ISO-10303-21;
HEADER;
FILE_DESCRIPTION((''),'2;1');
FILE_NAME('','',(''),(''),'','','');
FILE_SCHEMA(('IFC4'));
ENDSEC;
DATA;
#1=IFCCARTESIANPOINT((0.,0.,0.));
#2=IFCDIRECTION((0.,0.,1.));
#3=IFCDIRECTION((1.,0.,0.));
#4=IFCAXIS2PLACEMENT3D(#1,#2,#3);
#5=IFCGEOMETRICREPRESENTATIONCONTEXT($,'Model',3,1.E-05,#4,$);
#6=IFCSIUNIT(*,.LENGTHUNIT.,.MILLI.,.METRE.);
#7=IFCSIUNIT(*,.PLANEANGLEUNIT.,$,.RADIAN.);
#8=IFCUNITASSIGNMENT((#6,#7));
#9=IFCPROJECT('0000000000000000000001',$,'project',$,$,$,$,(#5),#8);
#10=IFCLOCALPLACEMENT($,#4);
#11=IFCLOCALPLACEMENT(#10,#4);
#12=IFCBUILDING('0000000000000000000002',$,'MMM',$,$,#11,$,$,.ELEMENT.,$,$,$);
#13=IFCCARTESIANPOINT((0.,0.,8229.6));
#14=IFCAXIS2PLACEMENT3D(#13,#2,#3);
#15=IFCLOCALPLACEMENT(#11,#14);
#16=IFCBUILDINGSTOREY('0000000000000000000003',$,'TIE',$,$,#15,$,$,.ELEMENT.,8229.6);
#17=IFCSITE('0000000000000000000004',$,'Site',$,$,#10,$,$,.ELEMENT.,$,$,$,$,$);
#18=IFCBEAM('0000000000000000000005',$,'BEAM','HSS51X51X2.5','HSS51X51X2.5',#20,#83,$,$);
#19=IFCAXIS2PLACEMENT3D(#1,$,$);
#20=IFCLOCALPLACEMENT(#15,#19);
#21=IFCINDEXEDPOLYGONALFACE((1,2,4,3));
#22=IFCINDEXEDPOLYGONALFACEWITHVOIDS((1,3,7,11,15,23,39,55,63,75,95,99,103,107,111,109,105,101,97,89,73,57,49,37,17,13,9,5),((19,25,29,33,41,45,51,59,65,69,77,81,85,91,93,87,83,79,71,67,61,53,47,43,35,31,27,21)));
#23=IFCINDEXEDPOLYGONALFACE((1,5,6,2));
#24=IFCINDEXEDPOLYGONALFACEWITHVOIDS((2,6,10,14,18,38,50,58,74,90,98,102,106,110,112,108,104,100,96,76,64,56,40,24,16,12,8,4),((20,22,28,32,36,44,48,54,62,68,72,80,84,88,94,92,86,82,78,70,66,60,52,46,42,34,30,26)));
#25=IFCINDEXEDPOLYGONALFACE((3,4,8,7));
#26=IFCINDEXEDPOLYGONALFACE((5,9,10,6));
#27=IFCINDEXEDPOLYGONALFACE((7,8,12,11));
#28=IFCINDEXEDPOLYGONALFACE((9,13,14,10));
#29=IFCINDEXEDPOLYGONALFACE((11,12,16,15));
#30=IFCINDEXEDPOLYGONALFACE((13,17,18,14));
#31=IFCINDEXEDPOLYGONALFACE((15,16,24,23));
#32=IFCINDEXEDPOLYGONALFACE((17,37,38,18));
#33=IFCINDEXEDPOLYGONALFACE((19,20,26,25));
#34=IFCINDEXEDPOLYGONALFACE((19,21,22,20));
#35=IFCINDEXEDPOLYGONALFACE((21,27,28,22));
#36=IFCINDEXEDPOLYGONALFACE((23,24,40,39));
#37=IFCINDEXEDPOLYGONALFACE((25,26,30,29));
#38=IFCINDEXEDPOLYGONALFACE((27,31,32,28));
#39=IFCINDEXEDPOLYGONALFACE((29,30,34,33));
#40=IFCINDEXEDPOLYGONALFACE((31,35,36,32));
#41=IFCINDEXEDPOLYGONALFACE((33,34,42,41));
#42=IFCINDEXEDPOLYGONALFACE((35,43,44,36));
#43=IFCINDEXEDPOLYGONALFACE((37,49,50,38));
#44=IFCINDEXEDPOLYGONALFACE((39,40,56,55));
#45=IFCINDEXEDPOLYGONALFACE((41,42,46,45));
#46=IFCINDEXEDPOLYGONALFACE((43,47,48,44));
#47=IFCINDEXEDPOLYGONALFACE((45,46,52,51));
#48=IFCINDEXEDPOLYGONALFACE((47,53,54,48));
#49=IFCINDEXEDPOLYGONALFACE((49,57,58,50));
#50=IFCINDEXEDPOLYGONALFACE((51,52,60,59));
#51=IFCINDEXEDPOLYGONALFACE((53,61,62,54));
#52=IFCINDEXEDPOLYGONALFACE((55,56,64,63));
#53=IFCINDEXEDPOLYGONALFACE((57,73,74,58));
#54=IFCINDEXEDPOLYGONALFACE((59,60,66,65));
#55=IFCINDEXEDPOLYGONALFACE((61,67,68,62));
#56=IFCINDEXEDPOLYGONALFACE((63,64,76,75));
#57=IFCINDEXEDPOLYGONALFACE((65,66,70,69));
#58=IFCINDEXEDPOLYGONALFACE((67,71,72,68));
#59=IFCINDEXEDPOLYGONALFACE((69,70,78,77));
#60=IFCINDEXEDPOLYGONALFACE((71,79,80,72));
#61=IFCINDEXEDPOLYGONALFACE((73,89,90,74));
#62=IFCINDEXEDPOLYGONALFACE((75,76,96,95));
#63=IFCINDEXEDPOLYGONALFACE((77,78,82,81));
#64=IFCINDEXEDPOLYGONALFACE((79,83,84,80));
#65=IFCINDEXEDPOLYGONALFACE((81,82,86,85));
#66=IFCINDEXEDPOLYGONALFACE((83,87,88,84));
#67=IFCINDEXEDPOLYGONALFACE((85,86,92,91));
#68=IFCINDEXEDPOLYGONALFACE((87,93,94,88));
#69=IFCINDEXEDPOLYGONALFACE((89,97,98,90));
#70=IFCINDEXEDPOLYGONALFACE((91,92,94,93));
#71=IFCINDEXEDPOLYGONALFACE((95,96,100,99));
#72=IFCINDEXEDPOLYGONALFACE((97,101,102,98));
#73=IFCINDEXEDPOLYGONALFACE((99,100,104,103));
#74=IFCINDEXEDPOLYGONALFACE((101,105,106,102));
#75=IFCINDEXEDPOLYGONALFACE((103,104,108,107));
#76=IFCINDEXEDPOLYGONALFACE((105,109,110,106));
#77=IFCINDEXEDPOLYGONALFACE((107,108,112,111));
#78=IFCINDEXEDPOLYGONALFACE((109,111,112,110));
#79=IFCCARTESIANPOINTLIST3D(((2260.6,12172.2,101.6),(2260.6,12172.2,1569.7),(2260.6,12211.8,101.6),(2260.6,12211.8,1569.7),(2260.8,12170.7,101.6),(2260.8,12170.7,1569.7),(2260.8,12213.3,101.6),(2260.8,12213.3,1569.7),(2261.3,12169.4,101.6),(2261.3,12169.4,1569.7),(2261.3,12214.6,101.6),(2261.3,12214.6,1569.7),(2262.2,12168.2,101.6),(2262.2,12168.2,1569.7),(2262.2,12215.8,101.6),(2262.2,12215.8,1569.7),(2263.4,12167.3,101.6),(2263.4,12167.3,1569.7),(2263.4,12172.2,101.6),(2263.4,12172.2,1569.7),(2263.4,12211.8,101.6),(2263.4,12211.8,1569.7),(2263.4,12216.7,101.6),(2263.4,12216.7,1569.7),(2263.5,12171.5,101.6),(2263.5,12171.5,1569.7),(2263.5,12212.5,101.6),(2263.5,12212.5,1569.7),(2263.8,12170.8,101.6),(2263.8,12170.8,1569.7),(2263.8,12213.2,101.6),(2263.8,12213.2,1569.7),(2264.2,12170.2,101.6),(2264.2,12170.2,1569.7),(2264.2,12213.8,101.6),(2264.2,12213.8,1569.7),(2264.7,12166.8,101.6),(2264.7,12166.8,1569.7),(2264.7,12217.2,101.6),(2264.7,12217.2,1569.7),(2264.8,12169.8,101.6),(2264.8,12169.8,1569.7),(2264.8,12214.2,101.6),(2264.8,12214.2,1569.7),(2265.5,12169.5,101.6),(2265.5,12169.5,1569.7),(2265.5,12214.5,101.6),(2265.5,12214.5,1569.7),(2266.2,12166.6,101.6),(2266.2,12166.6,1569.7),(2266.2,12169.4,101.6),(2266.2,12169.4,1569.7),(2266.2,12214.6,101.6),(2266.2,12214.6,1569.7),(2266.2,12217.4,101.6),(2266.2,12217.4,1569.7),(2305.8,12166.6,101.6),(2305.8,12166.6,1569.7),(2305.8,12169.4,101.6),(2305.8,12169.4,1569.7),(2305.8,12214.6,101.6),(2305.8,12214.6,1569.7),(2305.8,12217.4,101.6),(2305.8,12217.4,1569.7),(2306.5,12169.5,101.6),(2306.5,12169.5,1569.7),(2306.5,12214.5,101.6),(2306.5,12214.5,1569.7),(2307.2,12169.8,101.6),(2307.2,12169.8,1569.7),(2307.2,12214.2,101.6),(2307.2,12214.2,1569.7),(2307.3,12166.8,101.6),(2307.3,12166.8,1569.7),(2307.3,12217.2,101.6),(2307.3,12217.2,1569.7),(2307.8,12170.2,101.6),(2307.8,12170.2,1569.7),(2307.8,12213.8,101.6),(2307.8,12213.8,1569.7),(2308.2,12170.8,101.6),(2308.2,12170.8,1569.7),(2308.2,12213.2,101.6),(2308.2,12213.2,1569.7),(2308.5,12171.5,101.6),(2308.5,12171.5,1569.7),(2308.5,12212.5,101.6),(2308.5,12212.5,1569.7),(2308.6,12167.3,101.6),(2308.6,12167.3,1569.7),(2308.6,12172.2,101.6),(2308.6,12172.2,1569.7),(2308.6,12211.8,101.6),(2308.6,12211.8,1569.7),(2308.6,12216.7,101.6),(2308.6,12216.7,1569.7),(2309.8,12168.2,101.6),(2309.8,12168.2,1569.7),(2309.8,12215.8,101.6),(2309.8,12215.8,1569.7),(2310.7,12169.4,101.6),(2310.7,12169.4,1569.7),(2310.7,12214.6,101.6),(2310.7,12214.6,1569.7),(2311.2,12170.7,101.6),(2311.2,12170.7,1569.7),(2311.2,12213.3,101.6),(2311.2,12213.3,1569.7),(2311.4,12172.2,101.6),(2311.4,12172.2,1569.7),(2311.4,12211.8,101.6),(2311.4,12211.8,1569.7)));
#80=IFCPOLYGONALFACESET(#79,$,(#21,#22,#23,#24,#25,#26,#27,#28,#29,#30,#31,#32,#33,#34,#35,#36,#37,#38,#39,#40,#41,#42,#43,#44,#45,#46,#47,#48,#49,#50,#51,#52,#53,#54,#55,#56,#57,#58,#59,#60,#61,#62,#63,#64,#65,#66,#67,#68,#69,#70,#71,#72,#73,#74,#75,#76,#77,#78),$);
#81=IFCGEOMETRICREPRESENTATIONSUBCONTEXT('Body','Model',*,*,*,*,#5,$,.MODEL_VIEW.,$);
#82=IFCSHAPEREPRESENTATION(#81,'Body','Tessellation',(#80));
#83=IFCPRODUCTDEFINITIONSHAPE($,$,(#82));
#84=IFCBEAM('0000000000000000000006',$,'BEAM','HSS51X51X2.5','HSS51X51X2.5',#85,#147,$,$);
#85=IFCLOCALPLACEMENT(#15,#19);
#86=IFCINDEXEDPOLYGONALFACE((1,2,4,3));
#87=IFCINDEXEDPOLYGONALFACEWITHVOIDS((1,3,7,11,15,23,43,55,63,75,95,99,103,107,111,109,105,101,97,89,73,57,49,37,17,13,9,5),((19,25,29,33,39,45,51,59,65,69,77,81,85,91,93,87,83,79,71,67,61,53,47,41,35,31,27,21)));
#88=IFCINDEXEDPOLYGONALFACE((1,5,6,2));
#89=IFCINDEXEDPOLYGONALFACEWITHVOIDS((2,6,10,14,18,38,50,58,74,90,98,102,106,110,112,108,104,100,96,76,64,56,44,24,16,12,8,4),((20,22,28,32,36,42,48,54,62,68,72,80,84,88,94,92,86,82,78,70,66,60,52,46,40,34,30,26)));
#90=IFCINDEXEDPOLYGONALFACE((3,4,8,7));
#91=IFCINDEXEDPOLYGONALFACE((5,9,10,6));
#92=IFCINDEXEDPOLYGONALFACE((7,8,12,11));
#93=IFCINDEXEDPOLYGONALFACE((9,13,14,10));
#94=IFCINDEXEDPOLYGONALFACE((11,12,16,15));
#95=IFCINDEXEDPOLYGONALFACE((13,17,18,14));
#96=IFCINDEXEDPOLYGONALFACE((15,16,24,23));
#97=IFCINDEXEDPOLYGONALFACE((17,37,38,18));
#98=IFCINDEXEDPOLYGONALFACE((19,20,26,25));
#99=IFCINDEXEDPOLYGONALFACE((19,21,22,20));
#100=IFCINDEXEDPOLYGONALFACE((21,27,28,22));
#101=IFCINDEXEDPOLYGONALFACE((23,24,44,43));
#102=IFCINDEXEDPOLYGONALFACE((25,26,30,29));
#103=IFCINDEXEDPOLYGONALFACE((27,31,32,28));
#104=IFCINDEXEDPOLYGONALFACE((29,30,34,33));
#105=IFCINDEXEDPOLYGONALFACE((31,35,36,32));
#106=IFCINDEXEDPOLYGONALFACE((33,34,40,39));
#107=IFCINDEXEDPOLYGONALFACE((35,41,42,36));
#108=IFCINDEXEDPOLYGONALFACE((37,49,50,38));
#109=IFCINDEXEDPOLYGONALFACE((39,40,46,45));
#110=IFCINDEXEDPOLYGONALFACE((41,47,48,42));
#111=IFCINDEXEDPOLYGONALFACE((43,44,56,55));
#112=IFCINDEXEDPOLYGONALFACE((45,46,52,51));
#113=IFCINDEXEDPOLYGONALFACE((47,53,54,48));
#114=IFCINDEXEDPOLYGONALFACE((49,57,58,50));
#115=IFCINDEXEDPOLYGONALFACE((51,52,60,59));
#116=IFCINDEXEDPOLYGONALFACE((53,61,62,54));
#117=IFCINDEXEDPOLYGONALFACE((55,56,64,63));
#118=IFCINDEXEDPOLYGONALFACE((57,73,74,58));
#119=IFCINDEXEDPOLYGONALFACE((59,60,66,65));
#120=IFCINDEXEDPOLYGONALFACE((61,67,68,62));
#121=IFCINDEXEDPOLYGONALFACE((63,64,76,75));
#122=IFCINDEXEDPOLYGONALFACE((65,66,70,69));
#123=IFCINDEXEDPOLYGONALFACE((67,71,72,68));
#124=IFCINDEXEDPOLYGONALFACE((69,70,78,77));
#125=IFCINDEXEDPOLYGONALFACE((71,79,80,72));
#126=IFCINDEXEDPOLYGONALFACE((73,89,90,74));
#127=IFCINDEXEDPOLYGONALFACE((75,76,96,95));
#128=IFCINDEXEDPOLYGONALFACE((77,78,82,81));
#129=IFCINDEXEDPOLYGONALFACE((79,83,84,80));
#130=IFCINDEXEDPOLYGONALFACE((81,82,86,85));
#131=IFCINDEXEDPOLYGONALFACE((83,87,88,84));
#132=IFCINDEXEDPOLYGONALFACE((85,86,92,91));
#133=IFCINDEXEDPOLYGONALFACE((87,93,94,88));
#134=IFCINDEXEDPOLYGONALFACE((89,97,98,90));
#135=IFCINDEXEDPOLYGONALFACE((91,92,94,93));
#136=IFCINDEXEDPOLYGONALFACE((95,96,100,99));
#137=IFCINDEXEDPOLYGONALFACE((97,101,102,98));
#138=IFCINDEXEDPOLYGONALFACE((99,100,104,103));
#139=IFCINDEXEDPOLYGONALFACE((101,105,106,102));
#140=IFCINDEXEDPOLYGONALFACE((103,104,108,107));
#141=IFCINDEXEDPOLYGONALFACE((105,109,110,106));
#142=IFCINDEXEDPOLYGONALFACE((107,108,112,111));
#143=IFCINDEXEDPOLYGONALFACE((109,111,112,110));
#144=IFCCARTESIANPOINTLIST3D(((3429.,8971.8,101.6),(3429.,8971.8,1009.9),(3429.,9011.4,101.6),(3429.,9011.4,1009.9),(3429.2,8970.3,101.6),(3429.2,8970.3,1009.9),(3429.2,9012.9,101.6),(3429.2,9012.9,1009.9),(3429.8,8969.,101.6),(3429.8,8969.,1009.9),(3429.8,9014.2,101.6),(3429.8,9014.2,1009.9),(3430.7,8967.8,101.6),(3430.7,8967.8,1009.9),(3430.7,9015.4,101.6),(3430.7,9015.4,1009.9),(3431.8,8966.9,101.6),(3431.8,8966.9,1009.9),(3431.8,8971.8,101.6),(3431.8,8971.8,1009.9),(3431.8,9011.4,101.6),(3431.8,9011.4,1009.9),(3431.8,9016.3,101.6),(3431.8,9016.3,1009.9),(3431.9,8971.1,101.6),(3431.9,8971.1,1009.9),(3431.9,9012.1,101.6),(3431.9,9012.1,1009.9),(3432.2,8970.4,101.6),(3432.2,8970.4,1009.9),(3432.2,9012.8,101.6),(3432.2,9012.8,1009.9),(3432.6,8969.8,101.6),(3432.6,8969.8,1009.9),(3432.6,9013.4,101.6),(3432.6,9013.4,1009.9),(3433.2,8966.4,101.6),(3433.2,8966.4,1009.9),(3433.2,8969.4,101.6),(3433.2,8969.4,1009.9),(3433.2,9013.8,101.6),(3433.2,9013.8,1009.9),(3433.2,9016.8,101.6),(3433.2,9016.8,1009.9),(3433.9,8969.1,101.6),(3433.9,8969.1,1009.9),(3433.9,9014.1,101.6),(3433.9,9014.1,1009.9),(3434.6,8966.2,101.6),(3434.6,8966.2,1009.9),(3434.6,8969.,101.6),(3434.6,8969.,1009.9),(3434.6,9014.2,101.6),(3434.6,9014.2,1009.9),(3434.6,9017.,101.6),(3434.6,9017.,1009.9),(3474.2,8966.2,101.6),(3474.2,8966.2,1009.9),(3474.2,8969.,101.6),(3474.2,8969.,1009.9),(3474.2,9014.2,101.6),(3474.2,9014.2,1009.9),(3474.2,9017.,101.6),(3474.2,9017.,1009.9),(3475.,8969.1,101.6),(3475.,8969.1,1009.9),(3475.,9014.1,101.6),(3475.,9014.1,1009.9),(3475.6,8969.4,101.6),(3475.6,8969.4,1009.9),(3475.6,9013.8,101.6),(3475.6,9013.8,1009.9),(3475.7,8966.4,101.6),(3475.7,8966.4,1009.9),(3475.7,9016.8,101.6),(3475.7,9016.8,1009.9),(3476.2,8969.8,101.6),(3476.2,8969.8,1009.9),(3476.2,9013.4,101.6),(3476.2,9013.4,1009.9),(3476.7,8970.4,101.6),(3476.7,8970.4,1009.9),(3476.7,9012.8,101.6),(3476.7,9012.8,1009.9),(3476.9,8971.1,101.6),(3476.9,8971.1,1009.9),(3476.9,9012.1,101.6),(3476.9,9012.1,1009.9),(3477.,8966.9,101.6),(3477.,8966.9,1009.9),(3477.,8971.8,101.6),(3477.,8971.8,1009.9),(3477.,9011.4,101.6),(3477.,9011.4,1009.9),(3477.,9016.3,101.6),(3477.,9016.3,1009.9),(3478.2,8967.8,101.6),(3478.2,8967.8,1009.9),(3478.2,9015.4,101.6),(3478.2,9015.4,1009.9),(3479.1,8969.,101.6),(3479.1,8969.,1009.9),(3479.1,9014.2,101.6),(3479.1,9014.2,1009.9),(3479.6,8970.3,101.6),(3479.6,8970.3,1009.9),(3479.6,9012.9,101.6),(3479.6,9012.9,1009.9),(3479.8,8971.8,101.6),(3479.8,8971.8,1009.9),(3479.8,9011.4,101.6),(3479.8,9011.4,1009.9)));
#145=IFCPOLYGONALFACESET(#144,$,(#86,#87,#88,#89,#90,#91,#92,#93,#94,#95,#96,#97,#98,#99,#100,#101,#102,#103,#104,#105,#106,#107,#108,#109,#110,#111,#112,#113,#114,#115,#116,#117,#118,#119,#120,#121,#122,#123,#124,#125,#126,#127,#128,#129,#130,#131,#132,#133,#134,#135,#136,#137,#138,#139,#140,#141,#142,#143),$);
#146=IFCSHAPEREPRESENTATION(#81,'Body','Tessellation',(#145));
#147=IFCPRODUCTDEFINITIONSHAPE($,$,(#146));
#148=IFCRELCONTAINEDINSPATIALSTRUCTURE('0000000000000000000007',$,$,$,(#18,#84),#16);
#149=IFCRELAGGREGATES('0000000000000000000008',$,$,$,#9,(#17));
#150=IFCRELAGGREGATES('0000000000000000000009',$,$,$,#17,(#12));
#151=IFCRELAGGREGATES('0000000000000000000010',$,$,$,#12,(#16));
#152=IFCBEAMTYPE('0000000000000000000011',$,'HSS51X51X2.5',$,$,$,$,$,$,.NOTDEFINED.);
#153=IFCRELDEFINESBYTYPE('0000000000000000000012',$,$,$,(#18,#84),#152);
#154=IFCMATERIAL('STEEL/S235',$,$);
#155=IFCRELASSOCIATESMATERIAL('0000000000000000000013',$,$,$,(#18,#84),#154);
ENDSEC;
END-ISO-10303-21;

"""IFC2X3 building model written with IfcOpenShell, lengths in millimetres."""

from ifc_helpers import new_model, si_unit, frame, origin_with_axes, origin_2d_with_axis, place, context, subcontext, project, spatial, hollow_rectangle, extrude, material, type_object, element, save


model = new_model("IFC2X3")

# Units and contexts
model_context = context("Model", 3, precision=1e-05, world=origin_with_axes())
body_context = subcontext(model_context, "Body", "Model", "MODEL_VIEW")
ifc_project = project(units=[si_unit("LENGTHUNIT", "METRE", prefix="MILLI"), si_unit("PLANEANGLEUNIT", "RADIAN")], contexts=[model_context])

# Site, building, storey
site_placement = place(None, origin_with_axes())
site = spatial("IfcSite", under=ifc_project, at=site_placement, Name="Site", CompositionType="ELEMENT")
building_placement = place(site_placement, origin_with_axes())
building = spatial("IfcBuilding", under=site, at=building_placement, Name="MMM", CompositionType="ELEMENT")
storey_placement = place(building_placement, frame((0.0, 0.0, 8229.6), z_axis=(0.0, 0.0, 1.0), x_axis=(1.0, 0.0, 0.0)))
storey = spatial("IfcBuildingStorey", under=building, at=storey_placement, Name="TIE", CompositionType="ELEMENT", Elevation=8229.6)

# Beams
ifc_material = material(Name="STEEL/S235")
beam_type_1 = type_object("IfcBeamType", Name="HSS51X51X2.5", PredefinedType="NOTDEFINED")
beam_1_placement = place(storey_placement, frame((2286.0, 12192.0, 1569.7), z_axis=(1.0, 0.0, 0.0), x_axis=(0.0, 0.0, -1.0)))
element("IfcBeam", 1, at=beam_1_placement, inside=storey, type_object=beam_type_1, material=ifc_material, Name="BEAM", Description="HSS51X51X2.5", ObjectType="HSS51X51X2.5", context=body_context, shape_type="SweptSolid", body=[
    extrude(hollow_rectangle(XDim=50.8, YDim=50.8, WallThickness=2.8, InnerFilletRadius=2.8, OuterFilletRadius=5.6, at=origin_2d_with_axis()), frame((1468.1, 0.0, 0.0), z_axis=(-1.0, 0.0, 0.0), x_axis=(0.0, -1.0, 0.0)), (0.0, 0.0, 1.0), 1468.1),
])
beam_2_placement = place(storey_placement, frame((3454.4, 8991.6, 1009.9), z_axis=(-1.0, 0.0, 0.0), x_axis=(0.0, 0.0, -1.0)))
element("IfcBeam", 2, at=beam_2_placement, inside=storey, type_object=beam_type_1, material=ifc_material, Name="BEAM", Description="HSS51X51X2.5", ObjectType="HSS51X51X2.5", context=body_context, shape_type="SweptSolid", body=[
    extrude(hollow_rectangle(XDim=50.8, YDim=50.8, WallThickness=2.8, InnerFilletRadius=2.8, OuterFilletRadius=5.6, at=origin_2d_with_axis()), frame((908.3, 0.0, 0.0), z_axis=(-1.0, 0.0, 0.0), x_axis=(0.0, -1.0, 0.0)), (0.0, 0.0, 1.0), 908.3),
])

save(model, "model.ifc")
